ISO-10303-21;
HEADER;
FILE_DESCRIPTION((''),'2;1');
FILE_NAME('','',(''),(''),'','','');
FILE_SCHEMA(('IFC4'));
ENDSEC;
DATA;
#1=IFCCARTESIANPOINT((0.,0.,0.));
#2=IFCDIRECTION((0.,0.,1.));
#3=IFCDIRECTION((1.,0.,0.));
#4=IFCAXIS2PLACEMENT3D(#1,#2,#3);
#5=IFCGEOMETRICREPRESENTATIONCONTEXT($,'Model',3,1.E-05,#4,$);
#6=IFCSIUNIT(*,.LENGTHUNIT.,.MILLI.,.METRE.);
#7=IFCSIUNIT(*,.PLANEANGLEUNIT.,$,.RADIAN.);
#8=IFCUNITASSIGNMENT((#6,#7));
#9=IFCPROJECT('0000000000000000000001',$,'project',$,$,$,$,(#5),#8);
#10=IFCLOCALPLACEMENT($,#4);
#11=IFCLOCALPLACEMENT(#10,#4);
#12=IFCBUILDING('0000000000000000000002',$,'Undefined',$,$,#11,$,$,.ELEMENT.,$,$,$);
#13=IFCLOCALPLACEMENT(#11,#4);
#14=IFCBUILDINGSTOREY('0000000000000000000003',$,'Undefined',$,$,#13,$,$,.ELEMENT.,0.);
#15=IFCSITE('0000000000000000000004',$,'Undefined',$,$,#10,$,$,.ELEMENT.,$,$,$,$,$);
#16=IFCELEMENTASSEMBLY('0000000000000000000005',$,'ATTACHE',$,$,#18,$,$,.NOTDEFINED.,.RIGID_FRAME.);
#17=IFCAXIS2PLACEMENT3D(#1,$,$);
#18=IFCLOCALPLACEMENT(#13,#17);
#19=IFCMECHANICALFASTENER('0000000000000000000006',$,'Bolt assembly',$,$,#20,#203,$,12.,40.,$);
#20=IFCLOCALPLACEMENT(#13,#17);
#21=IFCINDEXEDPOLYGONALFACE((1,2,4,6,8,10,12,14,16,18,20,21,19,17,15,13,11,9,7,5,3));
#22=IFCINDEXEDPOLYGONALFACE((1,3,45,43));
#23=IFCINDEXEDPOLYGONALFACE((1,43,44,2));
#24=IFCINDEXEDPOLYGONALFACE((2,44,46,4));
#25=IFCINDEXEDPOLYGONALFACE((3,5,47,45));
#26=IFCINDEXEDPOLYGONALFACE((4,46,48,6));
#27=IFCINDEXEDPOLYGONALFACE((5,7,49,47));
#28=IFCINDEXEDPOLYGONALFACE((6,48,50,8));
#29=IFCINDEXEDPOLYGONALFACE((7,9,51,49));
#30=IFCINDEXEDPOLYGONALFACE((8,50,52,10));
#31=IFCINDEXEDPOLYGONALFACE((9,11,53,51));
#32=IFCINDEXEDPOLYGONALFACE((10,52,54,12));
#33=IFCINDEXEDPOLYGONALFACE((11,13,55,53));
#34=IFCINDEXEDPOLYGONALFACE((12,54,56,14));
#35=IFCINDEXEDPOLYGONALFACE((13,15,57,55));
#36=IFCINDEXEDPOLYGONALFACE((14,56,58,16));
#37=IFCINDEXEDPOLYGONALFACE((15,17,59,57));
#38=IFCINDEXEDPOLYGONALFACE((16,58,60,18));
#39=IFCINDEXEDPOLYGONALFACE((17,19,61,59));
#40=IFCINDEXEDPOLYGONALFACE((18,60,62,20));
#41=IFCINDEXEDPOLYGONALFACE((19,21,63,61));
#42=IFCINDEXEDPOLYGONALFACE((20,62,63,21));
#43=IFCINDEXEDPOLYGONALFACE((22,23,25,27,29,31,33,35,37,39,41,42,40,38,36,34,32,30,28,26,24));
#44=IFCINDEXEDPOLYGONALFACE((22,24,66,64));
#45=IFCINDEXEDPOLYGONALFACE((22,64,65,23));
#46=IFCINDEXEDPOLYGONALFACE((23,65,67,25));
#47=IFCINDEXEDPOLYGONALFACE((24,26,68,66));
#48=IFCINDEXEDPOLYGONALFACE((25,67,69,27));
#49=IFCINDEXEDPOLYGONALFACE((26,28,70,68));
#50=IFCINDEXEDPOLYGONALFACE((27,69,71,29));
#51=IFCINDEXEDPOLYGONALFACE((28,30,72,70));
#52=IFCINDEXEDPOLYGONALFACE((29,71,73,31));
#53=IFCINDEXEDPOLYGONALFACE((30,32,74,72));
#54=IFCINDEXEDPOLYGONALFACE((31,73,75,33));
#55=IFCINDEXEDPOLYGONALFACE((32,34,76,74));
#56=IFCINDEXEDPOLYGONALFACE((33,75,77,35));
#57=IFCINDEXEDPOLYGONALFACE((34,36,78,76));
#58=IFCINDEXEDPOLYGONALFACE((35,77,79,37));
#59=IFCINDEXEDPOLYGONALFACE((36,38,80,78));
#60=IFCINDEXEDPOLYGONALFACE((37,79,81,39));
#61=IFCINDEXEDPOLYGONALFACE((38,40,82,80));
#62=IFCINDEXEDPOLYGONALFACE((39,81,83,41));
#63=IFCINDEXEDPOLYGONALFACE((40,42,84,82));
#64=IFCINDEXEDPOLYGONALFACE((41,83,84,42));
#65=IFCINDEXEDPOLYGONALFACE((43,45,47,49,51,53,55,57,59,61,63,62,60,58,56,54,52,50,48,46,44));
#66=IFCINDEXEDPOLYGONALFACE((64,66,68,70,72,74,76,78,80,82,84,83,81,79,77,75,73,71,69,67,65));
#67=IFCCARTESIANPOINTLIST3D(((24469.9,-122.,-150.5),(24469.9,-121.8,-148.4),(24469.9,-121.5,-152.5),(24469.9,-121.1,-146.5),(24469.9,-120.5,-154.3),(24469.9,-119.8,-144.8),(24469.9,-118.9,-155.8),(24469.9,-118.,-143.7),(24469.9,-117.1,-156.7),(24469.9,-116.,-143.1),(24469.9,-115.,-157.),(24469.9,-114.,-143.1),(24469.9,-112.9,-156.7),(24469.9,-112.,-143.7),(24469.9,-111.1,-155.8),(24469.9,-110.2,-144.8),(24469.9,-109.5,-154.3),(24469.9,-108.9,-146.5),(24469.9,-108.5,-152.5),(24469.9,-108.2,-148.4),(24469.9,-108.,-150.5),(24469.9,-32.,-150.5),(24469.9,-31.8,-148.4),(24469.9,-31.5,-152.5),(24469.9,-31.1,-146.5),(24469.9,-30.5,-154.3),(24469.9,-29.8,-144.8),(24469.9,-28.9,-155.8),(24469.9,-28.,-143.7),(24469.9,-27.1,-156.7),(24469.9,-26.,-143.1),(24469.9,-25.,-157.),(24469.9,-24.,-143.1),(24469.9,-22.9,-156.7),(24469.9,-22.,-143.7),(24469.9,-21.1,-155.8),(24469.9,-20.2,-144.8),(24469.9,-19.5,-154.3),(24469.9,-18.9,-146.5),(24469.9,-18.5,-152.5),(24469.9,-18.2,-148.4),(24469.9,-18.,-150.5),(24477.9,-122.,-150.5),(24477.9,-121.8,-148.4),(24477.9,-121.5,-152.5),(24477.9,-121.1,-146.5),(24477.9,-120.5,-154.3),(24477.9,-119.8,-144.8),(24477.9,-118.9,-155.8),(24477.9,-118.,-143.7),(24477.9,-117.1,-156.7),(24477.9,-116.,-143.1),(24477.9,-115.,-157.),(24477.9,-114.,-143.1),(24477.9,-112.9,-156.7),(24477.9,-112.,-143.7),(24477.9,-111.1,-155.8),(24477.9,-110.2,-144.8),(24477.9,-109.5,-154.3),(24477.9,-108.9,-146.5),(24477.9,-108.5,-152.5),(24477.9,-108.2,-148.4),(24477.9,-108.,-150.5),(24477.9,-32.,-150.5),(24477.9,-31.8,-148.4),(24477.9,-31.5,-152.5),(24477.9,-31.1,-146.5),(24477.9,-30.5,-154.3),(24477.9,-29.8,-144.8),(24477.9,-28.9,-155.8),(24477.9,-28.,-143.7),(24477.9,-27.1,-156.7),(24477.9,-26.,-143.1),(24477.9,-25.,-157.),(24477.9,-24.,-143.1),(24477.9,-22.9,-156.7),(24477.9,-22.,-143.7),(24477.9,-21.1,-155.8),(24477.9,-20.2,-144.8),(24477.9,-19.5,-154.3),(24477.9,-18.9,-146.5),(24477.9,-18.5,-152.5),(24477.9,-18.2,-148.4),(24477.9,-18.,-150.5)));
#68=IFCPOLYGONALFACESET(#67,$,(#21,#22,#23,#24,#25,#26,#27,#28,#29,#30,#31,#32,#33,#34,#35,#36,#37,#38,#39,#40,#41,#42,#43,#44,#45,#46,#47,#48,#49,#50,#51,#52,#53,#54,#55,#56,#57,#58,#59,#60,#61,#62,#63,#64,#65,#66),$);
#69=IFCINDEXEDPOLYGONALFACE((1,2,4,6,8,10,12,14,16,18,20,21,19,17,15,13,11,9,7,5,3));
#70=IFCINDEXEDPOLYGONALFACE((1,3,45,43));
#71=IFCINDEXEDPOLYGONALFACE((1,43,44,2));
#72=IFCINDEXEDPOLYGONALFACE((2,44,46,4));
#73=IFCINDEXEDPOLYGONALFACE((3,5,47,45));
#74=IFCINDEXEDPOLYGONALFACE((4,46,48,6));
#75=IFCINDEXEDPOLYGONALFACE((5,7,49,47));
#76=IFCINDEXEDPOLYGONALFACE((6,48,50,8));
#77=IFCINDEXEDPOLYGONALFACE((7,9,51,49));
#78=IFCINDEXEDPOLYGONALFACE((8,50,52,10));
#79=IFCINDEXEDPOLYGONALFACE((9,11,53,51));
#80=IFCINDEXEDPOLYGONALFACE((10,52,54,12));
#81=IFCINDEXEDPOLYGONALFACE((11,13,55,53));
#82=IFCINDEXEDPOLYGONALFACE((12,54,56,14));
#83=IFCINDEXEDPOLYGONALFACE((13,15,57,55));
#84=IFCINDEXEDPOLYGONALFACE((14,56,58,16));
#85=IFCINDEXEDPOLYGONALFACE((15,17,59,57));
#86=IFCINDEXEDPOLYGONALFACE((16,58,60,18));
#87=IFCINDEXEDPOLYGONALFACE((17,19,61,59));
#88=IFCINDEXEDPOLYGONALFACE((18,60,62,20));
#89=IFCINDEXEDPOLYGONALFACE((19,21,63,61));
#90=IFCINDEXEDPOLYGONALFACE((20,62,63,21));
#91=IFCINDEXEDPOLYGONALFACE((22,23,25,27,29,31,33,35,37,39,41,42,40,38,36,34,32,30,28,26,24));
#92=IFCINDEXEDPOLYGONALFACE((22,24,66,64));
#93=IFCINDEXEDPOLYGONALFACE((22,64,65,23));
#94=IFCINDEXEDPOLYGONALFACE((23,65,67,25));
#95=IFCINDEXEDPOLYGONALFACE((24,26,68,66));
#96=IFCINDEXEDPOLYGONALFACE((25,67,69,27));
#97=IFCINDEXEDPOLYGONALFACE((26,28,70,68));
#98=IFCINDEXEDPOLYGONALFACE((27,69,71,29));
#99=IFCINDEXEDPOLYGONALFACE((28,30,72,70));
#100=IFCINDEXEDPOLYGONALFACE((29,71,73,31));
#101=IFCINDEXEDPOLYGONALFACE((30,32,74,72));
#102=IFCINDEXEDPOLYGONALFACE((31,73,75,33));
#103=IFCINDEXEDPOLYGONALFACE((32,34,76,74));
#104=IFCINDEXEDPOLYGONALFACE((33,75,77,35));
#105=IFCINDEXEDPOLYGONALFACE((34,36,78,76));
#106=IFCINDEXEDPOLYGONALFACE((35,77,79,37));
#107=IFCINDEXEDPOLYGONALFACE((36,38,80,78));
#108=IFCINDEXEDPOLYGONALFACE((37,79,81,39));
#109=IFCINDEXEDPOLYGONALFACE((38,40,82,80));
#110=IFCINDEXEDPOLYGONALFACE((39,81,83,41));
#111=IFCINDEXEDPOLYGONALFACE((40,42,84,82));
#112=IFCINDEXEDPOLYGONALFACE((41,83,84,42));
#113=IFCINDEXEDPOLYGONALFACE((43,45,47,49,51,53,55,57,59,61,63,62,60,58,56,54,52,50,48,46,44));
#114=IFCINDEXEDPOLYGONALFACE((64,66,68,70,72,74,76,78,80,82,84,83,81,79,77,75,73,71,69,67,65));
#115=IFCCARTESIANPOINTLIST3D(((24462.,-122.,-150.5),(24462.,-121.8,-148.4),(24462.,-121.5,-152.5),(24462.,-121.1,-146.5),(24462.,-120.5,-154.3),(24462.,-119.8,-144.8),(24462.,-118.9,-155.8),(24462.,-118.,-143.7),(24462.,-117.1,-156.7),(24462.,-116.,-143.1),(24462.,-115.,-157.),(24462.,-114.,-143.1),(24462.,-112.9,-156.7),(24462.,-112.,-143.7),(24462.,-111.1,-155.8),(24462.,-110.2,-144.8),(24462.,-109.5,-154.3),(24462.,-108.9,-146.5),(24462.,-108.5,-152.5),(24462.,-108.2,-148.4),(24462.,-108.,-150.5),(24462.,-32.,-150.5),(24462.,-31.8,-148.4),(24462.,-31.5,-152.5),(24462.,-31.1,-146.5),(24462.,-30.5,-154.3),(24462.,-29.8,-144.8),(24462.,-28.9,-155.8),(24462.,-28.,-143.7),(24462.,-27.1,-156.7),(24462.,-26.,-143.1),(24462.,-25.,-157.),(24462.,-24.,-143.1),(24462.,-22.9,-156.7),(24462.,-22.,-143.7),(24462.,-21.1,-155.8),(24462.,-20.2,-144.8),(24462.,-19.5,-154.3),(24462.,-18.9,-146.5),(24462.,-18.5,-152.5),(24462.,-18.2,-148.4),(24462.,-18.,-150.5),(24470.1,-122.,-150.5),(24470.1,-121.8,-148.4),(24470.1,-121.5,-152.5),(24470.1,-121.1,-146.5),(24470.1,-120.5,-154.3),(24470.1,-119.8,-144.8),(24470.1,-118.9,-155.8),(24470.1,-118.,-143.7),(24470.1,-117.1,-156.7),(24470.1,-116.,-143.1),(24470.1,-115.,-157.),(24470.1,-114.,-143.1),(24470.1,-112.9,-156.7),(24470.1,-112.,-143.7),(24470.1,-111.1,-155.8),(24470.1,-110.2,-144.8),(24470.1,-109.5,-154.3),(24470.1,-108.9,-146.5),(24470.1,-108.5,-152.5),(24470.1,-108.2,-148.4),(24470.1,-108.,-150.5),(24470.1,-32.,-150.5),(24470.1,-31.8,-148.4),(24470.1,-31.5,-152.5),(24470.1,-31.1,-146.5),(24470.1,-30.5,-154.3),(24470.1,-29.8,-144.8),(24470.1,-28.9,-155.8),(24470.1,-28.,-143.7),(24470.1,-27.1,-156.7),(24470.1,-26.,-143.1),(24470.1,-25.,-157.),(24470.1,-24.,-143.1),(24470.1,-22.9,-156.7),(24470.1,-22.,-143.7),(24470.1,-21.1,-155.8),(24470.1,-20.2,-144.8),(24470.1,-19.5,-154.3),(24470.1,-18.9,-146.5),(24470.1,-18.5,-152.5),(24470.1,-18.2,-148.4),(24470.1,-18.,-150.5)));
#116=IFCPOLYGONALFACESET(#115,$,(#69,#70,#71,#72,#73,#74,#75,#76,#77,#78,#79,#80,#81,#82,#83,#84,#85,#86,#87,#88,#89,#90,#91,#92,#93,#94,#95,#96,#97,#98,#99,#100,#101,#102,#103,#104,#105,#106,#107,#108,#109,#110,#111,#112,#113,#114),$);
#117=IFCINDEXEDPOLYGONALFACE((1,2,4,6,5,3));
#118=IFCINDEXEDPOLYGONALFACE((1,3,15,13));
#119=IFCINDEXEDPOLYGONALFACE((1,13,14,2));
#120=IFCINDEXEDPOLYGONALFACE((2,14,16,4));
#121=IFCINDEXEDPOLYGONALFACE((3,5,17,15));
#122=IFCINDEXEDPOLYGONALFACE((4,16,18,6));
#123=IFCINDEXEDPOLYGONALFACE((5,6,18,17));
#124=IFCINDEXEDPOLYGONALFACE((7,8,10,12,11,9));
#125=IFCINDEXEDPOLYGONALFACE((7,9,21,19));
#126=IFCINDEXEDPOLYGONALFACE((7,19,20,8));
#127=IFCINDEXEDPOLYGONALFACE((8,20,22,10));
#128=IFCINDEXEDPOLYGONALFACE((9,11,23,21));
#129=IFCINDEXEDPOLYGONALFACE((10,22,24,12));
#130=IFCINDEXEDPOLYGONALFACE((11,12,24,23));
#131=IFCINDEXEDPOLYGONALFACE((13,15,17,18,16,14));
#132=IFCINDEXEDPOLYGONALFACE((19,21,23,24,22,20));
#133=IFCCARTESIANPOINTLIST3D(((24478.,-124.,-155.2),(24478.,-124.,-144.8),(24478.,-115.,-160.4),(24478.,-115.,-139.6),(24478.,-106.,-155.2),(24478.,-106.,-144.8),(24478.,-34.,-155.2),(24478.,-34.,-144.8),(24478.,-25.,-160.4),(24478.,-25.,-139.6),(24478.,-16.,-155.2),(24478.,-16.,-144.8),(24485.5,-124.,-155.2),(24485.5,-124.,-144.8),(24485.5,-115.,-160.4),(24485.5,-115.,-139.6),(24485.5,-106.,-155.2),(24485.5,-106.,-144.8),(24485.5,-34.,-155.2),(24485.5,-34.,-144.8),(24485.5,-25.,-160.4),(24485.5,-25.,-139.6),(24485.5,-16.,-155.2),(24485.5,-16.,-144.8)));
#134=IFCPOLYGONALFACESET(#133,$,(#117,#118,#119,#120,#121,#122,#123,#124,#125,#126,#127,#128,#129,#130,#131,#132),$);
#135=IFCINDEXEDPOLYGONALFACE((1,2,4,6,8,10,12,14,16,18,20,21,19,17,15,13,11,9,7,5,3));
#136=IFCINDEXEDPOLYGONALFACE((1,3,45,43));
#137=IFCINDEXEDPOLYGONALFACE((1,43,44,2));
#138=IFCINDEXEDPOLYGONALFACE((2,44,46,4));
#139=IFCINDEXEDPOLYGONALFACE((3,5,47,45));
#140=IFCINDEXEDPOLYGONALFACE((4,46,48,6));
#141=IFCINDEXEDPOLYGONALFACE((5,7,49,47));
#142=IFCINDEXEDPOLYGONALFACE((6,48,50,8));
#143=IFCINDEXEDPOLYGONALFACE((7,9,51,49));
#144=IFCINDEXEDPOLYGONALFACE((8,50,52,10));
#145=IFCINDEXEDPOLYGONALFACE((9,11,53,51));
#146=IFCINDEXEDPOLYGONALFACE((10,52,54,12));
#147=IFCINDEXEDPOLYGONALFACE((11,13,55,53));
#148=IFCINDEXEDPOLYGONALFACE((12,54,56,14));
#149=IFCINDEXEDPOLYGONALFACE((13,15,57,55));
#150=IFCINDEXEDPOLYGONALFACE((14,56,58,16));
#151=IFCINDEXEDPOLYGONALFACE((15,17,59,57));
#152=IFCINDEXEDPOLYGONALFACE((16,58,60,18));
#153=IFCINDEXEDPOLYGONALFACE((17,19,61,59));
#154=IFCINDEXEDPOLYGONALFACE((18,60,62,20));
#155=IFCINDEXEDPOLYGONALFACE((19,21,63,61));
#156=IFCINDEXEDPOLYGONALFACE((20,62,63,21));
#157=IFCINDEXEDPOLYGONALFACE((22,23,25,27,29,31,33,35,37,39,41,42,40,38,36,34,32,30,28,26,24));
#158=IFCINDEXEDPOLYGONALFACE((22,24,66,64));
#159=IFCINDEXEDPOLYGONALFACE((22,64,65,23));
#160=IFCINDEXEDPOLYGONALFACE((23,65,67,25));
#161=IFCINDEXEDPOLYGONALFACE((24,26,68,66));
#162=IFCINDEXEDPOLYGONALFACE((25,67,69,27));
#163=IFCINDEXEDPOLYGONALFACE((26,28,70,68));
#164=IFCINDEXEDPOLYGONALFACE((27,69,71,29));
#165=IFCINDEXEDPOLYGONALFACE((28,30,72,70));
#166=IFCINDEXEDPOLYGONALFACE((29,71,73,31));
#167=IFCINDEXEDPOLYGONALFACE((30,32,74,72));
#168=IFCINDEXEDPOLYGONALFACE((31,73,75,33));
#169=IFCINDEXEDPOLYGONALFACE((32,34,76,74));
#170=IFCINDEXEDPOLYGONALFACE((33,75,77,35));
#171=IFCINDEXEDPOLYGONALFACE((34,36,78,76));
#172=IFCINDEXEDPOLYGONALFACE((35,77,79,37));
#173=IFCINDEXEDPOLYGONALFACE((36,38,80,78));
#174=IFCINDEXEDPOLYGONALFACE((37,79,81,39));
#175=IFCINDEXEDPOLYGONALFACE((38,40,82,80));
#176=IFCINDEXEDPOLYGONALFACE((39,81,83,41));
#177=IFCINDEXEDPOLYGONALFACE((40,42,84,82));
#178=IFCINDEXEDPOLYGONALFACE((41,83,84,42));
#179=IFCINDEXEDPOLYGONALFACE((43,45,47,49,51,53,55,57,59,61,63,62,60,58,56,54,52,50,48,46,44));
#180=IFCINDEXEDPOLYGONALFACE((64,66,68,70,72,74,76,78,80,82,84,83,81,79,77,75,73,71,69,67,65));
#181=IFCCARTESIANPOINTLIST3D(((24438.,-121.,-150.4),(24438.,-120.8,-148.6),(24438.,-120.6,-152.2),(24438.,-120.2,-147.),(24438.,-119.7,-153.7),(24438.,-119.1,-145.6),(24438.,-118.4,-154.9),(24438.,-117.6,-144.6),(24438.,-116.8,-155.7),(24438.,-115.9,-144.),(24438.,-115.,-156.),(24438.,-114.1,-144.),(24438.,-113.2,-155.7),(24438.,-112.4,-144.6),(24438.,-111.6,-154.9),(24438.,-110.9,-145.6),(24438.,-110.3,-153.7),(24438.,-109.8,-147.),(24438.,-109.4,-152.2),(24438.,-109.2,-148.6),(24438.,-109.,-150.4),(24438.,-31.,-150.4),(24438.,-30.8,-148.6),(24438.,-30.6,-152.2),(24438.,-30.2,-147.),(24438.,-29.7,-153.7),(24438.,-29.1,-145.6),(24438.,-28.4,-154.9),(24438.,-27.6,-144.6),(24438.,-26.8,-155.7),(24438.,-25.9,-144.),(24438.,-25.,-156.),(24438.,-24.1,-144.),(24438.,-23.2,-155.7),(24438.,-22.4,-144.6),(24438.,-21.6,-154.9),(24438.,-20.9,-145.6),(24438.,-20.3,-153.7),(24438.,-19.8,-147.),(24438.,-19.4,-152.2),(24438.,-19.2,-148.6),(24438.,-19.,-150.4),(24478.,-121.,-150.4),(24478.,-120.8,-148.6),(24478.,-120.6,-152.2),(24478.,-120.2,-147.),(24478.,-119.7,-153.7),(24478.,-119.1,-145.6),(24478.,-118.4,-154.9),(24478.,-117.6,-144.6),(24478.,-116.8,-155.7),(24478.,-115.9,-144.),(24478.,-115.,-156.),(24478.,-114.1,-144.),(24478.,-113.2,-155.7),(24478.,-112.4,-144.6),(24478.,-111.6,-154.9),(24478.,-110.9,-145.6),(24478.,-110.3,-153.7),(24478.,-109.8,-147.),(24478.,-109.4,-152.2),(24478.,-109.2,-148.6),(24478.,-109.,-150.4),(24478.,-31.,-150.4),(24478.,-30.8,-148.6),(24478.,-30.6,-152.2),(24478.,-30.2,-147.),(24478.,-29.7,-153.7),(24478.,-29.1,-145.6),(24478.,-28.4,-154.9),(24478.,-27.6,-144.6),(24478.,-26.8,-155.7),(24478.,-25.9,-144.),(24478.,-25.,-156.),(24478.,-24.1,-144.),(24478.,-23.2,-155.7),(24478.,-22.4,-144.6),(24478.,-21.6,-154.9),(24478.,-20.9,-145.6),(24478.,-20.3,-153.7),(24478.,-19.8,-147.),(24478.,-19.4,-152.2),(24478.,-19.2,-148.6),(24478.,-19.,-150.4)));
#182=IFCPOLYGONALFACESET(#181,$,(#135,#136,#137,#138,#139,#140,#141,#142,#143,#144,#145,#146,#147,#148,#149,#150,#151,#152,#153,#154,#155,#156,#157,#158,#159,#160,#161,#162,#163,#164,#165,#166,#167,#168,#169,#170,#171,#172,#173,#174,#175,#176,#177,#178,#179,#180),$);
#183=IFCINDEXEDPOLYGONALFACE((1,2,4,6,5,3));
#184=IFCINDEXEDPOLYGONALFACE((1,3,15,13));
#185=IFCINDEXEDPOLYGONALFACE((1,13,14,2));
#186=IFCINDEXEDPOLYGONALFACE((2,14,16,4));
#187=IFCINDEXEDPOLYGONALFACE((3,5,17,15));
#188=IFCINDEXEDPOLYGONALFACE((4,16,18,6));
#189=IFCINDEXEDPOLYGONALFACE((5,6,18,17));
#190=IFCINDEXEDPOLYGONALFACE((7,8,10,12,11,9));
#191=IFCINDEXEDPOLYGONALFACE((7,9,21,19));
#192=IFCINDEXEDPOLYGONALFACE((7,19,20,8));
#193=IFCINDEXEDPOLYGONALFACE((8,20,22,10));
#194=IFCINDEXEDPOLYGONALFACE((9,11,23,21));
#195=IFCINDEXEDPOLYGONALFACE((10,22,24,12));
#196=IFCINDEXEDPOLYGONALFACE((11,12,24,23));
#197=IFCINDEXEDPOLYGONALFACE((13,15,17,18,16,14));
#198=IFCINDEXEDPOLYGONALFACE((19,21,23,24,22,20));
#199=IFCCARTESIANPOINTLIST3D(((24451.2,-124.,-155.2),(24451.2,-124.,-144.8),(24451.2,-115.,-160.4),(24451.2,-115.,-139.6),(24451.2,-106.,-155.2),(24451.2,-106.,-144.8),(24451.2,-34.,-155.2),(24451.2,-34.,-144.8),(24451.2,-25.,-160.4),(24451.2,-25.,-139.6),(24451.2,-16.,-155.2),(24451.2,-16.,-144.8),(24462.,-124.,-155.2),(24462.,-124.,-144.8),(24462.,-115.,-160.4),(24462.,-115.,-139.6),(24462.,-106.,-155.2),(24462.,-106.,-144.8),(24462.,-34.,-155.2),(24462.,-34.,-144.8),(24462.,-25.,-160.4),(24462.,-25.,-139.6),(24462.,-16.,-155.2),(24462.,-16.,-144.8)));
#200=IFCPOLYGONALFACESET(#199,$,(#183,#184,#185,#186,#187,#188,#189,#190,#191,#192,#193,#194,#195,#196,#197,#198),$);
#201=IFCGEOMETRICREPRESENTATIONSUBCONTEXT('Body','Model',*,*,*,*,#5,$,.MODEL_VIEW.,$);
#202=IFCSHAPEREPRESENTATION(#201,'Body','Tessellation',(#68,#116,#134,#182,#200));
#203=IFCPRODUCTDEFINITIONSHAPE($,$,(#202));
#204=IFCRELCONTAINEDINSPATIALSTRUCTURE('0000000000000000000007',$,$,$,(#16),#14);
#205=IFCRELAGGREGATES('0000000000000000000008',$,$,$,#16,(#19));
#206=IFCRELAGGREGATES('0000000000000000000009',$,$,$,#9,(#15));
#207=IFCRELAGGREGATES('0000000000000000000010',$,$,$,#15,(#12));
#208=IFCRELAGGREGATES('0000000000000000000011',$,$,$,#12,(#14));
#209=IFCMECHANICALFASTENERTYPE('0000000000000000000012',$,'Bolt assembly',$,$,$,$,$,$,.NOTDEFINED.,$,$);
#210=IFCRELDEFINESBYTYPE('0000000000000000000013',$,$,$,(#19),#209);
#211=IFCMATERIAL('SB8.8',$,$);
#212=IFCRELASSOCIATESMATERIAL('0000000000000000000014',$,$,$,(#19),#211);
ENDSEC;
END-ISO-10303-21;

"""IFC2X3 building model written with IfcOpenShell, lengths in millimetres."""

from ifc_helpers import new_model, si_unit, frame, origin_with_axes, origin_2d_with_axis, place, context, subcontext, project, spatial, polyline, circle, outline, extrude, source, transform, mapped, material, type_object, element, aggregate, save


model = new_model("IFC2X3")

# Units and contexts
model_context = context("Model", 3, precision=1e-05, world=origin_with_axes())
body_context = subcontext(model_context, "Body", "Model", "MODEL_VIEW")
ifc_project = project(units=[si_unit("LENGTHUNIT", "METRE", prefix="MILLI"), si_unit("PLANEANGLEUNIT", "RADIAN")], contexts=[model_context])

# Site, building, storey
site_placement = place(None, origin_with_axes())
site = spatial("IfcSite", under=ifc_project, at=site_placement, Name="Undefined", CompositionType="ELEMENT")
building_placement = place(site_placement, origin_with_axes())
building = spatial("IfcBuilding", under=site, at=building_placement, Name="Undefined", CompositionType="ELEMENT")
storey_placement = place(building_placement, origin_with_axes())
storey = spatial("IfcBuildingStorey", under=building, at=storey_placement, Name="Undefined", CompositionType="ELEMENT", Elevation=0.0)

# Element assembly
assembly_1_placement = place(storey_placement, origin_with_axes())
assembly_1 = element("IfcElementAssembly", 1, at=assembly_1_placement, inside=storey, Name="ATTACHE", AssemblyPlace="NOTDEFINED", PredefinedType="RIGID_FRAME")

# Mechanical fastener
ifc_material_1 = material(Name="SB8.8")
mechanical_fastener_type = type_object("IfcMechanicalFastenerType", Name="Bolt assembly")
shared_shape_1 = source(origin_with_axes(), body_context, "Body", "SweptSolid", [
    extrude(circle(Radius=7.0, at=origin_2d_with_axis()), frame((0.0, -10.4, 0.0), z_axis=(0.0, 1.0, 0.0), x_axis=(1.0, 0.0, 0.0)), (0.0, 0.0, 1.0), 8.0),
    extrude(circle(Radius=7.0, at=origin_2d_with_axis()), frame((0.0, -2.6, 0.0), z_axis=(0.0, 1.0, 0.0), x_axis=(1.0, 0.0, 0.0)), (0.0, 0.0, 1.0), 8.1),
    extrude(outline(polyline([(10.4, 0.0), (5.2, 9.0), (-5.2, 9.0), (-10.4, 0.0), (-5.2, -9.0), (5.2, -9.0), (10.4, 0.0)])), frame((0.0, -18.0, 0.0), z_axis=(0.0, 1.0, 0.0), x_axis=(1.0, 0.0, 0.0)), (0.0, 0.0, 1.0), 7.5),
    extrude(circle(Radius=6.0, at=origin_2d_with_axis()), frame((0.0, -10.5, 0.0), z_axis=(0.0, 1.0, 0.0), x_axis=(1.0, 0.0, 0.0)), (0.0, 0.0, 1.0), 40.0),
    extrude(outline(polyline([(10.4, 0.0), (5.2, 9.0), (-5.2, 9.0), (-10.4, 0.0), (-5.2, -9.0), (5.2, -9.0), (10.4, 0.0)])), frame((0.0, 5.5, 0.0), z_axis=(0.0, 1.0, 0.0), x_axis=(1.0, 0.0, 0.0)), (0.0, 0.0, 1.0), 10.8),
])
mechanical_fastener_1_placement = place(assembly_1_placement, frame((24467.5, -70.0, -150.0), z_axis=(0.0, 1.0, 0.0), x_axis=(0.0, 0.0, -1.0)))
mechanical_fastener_1 = element("IfcMechanicalFastener", 2, at=mechanical_fastener_1_placement, type_object=mechanical_fastener_type, material=ifc_material_1, Name="Bolt assembly", NominalDiameter=12.0, NominalLength=40.0, context=body_context, shape_type="MappedRepresentation", body=[
    mapped(shared_shape_1, transform((0.0, 0.0, 45.0))),
    mapped(shared_shape_1, transform((0.0, 0.0, -45.0))),
])
aggregate(assembly_1, [mechanical_fastener_1])

save(model, "model.ifc")
